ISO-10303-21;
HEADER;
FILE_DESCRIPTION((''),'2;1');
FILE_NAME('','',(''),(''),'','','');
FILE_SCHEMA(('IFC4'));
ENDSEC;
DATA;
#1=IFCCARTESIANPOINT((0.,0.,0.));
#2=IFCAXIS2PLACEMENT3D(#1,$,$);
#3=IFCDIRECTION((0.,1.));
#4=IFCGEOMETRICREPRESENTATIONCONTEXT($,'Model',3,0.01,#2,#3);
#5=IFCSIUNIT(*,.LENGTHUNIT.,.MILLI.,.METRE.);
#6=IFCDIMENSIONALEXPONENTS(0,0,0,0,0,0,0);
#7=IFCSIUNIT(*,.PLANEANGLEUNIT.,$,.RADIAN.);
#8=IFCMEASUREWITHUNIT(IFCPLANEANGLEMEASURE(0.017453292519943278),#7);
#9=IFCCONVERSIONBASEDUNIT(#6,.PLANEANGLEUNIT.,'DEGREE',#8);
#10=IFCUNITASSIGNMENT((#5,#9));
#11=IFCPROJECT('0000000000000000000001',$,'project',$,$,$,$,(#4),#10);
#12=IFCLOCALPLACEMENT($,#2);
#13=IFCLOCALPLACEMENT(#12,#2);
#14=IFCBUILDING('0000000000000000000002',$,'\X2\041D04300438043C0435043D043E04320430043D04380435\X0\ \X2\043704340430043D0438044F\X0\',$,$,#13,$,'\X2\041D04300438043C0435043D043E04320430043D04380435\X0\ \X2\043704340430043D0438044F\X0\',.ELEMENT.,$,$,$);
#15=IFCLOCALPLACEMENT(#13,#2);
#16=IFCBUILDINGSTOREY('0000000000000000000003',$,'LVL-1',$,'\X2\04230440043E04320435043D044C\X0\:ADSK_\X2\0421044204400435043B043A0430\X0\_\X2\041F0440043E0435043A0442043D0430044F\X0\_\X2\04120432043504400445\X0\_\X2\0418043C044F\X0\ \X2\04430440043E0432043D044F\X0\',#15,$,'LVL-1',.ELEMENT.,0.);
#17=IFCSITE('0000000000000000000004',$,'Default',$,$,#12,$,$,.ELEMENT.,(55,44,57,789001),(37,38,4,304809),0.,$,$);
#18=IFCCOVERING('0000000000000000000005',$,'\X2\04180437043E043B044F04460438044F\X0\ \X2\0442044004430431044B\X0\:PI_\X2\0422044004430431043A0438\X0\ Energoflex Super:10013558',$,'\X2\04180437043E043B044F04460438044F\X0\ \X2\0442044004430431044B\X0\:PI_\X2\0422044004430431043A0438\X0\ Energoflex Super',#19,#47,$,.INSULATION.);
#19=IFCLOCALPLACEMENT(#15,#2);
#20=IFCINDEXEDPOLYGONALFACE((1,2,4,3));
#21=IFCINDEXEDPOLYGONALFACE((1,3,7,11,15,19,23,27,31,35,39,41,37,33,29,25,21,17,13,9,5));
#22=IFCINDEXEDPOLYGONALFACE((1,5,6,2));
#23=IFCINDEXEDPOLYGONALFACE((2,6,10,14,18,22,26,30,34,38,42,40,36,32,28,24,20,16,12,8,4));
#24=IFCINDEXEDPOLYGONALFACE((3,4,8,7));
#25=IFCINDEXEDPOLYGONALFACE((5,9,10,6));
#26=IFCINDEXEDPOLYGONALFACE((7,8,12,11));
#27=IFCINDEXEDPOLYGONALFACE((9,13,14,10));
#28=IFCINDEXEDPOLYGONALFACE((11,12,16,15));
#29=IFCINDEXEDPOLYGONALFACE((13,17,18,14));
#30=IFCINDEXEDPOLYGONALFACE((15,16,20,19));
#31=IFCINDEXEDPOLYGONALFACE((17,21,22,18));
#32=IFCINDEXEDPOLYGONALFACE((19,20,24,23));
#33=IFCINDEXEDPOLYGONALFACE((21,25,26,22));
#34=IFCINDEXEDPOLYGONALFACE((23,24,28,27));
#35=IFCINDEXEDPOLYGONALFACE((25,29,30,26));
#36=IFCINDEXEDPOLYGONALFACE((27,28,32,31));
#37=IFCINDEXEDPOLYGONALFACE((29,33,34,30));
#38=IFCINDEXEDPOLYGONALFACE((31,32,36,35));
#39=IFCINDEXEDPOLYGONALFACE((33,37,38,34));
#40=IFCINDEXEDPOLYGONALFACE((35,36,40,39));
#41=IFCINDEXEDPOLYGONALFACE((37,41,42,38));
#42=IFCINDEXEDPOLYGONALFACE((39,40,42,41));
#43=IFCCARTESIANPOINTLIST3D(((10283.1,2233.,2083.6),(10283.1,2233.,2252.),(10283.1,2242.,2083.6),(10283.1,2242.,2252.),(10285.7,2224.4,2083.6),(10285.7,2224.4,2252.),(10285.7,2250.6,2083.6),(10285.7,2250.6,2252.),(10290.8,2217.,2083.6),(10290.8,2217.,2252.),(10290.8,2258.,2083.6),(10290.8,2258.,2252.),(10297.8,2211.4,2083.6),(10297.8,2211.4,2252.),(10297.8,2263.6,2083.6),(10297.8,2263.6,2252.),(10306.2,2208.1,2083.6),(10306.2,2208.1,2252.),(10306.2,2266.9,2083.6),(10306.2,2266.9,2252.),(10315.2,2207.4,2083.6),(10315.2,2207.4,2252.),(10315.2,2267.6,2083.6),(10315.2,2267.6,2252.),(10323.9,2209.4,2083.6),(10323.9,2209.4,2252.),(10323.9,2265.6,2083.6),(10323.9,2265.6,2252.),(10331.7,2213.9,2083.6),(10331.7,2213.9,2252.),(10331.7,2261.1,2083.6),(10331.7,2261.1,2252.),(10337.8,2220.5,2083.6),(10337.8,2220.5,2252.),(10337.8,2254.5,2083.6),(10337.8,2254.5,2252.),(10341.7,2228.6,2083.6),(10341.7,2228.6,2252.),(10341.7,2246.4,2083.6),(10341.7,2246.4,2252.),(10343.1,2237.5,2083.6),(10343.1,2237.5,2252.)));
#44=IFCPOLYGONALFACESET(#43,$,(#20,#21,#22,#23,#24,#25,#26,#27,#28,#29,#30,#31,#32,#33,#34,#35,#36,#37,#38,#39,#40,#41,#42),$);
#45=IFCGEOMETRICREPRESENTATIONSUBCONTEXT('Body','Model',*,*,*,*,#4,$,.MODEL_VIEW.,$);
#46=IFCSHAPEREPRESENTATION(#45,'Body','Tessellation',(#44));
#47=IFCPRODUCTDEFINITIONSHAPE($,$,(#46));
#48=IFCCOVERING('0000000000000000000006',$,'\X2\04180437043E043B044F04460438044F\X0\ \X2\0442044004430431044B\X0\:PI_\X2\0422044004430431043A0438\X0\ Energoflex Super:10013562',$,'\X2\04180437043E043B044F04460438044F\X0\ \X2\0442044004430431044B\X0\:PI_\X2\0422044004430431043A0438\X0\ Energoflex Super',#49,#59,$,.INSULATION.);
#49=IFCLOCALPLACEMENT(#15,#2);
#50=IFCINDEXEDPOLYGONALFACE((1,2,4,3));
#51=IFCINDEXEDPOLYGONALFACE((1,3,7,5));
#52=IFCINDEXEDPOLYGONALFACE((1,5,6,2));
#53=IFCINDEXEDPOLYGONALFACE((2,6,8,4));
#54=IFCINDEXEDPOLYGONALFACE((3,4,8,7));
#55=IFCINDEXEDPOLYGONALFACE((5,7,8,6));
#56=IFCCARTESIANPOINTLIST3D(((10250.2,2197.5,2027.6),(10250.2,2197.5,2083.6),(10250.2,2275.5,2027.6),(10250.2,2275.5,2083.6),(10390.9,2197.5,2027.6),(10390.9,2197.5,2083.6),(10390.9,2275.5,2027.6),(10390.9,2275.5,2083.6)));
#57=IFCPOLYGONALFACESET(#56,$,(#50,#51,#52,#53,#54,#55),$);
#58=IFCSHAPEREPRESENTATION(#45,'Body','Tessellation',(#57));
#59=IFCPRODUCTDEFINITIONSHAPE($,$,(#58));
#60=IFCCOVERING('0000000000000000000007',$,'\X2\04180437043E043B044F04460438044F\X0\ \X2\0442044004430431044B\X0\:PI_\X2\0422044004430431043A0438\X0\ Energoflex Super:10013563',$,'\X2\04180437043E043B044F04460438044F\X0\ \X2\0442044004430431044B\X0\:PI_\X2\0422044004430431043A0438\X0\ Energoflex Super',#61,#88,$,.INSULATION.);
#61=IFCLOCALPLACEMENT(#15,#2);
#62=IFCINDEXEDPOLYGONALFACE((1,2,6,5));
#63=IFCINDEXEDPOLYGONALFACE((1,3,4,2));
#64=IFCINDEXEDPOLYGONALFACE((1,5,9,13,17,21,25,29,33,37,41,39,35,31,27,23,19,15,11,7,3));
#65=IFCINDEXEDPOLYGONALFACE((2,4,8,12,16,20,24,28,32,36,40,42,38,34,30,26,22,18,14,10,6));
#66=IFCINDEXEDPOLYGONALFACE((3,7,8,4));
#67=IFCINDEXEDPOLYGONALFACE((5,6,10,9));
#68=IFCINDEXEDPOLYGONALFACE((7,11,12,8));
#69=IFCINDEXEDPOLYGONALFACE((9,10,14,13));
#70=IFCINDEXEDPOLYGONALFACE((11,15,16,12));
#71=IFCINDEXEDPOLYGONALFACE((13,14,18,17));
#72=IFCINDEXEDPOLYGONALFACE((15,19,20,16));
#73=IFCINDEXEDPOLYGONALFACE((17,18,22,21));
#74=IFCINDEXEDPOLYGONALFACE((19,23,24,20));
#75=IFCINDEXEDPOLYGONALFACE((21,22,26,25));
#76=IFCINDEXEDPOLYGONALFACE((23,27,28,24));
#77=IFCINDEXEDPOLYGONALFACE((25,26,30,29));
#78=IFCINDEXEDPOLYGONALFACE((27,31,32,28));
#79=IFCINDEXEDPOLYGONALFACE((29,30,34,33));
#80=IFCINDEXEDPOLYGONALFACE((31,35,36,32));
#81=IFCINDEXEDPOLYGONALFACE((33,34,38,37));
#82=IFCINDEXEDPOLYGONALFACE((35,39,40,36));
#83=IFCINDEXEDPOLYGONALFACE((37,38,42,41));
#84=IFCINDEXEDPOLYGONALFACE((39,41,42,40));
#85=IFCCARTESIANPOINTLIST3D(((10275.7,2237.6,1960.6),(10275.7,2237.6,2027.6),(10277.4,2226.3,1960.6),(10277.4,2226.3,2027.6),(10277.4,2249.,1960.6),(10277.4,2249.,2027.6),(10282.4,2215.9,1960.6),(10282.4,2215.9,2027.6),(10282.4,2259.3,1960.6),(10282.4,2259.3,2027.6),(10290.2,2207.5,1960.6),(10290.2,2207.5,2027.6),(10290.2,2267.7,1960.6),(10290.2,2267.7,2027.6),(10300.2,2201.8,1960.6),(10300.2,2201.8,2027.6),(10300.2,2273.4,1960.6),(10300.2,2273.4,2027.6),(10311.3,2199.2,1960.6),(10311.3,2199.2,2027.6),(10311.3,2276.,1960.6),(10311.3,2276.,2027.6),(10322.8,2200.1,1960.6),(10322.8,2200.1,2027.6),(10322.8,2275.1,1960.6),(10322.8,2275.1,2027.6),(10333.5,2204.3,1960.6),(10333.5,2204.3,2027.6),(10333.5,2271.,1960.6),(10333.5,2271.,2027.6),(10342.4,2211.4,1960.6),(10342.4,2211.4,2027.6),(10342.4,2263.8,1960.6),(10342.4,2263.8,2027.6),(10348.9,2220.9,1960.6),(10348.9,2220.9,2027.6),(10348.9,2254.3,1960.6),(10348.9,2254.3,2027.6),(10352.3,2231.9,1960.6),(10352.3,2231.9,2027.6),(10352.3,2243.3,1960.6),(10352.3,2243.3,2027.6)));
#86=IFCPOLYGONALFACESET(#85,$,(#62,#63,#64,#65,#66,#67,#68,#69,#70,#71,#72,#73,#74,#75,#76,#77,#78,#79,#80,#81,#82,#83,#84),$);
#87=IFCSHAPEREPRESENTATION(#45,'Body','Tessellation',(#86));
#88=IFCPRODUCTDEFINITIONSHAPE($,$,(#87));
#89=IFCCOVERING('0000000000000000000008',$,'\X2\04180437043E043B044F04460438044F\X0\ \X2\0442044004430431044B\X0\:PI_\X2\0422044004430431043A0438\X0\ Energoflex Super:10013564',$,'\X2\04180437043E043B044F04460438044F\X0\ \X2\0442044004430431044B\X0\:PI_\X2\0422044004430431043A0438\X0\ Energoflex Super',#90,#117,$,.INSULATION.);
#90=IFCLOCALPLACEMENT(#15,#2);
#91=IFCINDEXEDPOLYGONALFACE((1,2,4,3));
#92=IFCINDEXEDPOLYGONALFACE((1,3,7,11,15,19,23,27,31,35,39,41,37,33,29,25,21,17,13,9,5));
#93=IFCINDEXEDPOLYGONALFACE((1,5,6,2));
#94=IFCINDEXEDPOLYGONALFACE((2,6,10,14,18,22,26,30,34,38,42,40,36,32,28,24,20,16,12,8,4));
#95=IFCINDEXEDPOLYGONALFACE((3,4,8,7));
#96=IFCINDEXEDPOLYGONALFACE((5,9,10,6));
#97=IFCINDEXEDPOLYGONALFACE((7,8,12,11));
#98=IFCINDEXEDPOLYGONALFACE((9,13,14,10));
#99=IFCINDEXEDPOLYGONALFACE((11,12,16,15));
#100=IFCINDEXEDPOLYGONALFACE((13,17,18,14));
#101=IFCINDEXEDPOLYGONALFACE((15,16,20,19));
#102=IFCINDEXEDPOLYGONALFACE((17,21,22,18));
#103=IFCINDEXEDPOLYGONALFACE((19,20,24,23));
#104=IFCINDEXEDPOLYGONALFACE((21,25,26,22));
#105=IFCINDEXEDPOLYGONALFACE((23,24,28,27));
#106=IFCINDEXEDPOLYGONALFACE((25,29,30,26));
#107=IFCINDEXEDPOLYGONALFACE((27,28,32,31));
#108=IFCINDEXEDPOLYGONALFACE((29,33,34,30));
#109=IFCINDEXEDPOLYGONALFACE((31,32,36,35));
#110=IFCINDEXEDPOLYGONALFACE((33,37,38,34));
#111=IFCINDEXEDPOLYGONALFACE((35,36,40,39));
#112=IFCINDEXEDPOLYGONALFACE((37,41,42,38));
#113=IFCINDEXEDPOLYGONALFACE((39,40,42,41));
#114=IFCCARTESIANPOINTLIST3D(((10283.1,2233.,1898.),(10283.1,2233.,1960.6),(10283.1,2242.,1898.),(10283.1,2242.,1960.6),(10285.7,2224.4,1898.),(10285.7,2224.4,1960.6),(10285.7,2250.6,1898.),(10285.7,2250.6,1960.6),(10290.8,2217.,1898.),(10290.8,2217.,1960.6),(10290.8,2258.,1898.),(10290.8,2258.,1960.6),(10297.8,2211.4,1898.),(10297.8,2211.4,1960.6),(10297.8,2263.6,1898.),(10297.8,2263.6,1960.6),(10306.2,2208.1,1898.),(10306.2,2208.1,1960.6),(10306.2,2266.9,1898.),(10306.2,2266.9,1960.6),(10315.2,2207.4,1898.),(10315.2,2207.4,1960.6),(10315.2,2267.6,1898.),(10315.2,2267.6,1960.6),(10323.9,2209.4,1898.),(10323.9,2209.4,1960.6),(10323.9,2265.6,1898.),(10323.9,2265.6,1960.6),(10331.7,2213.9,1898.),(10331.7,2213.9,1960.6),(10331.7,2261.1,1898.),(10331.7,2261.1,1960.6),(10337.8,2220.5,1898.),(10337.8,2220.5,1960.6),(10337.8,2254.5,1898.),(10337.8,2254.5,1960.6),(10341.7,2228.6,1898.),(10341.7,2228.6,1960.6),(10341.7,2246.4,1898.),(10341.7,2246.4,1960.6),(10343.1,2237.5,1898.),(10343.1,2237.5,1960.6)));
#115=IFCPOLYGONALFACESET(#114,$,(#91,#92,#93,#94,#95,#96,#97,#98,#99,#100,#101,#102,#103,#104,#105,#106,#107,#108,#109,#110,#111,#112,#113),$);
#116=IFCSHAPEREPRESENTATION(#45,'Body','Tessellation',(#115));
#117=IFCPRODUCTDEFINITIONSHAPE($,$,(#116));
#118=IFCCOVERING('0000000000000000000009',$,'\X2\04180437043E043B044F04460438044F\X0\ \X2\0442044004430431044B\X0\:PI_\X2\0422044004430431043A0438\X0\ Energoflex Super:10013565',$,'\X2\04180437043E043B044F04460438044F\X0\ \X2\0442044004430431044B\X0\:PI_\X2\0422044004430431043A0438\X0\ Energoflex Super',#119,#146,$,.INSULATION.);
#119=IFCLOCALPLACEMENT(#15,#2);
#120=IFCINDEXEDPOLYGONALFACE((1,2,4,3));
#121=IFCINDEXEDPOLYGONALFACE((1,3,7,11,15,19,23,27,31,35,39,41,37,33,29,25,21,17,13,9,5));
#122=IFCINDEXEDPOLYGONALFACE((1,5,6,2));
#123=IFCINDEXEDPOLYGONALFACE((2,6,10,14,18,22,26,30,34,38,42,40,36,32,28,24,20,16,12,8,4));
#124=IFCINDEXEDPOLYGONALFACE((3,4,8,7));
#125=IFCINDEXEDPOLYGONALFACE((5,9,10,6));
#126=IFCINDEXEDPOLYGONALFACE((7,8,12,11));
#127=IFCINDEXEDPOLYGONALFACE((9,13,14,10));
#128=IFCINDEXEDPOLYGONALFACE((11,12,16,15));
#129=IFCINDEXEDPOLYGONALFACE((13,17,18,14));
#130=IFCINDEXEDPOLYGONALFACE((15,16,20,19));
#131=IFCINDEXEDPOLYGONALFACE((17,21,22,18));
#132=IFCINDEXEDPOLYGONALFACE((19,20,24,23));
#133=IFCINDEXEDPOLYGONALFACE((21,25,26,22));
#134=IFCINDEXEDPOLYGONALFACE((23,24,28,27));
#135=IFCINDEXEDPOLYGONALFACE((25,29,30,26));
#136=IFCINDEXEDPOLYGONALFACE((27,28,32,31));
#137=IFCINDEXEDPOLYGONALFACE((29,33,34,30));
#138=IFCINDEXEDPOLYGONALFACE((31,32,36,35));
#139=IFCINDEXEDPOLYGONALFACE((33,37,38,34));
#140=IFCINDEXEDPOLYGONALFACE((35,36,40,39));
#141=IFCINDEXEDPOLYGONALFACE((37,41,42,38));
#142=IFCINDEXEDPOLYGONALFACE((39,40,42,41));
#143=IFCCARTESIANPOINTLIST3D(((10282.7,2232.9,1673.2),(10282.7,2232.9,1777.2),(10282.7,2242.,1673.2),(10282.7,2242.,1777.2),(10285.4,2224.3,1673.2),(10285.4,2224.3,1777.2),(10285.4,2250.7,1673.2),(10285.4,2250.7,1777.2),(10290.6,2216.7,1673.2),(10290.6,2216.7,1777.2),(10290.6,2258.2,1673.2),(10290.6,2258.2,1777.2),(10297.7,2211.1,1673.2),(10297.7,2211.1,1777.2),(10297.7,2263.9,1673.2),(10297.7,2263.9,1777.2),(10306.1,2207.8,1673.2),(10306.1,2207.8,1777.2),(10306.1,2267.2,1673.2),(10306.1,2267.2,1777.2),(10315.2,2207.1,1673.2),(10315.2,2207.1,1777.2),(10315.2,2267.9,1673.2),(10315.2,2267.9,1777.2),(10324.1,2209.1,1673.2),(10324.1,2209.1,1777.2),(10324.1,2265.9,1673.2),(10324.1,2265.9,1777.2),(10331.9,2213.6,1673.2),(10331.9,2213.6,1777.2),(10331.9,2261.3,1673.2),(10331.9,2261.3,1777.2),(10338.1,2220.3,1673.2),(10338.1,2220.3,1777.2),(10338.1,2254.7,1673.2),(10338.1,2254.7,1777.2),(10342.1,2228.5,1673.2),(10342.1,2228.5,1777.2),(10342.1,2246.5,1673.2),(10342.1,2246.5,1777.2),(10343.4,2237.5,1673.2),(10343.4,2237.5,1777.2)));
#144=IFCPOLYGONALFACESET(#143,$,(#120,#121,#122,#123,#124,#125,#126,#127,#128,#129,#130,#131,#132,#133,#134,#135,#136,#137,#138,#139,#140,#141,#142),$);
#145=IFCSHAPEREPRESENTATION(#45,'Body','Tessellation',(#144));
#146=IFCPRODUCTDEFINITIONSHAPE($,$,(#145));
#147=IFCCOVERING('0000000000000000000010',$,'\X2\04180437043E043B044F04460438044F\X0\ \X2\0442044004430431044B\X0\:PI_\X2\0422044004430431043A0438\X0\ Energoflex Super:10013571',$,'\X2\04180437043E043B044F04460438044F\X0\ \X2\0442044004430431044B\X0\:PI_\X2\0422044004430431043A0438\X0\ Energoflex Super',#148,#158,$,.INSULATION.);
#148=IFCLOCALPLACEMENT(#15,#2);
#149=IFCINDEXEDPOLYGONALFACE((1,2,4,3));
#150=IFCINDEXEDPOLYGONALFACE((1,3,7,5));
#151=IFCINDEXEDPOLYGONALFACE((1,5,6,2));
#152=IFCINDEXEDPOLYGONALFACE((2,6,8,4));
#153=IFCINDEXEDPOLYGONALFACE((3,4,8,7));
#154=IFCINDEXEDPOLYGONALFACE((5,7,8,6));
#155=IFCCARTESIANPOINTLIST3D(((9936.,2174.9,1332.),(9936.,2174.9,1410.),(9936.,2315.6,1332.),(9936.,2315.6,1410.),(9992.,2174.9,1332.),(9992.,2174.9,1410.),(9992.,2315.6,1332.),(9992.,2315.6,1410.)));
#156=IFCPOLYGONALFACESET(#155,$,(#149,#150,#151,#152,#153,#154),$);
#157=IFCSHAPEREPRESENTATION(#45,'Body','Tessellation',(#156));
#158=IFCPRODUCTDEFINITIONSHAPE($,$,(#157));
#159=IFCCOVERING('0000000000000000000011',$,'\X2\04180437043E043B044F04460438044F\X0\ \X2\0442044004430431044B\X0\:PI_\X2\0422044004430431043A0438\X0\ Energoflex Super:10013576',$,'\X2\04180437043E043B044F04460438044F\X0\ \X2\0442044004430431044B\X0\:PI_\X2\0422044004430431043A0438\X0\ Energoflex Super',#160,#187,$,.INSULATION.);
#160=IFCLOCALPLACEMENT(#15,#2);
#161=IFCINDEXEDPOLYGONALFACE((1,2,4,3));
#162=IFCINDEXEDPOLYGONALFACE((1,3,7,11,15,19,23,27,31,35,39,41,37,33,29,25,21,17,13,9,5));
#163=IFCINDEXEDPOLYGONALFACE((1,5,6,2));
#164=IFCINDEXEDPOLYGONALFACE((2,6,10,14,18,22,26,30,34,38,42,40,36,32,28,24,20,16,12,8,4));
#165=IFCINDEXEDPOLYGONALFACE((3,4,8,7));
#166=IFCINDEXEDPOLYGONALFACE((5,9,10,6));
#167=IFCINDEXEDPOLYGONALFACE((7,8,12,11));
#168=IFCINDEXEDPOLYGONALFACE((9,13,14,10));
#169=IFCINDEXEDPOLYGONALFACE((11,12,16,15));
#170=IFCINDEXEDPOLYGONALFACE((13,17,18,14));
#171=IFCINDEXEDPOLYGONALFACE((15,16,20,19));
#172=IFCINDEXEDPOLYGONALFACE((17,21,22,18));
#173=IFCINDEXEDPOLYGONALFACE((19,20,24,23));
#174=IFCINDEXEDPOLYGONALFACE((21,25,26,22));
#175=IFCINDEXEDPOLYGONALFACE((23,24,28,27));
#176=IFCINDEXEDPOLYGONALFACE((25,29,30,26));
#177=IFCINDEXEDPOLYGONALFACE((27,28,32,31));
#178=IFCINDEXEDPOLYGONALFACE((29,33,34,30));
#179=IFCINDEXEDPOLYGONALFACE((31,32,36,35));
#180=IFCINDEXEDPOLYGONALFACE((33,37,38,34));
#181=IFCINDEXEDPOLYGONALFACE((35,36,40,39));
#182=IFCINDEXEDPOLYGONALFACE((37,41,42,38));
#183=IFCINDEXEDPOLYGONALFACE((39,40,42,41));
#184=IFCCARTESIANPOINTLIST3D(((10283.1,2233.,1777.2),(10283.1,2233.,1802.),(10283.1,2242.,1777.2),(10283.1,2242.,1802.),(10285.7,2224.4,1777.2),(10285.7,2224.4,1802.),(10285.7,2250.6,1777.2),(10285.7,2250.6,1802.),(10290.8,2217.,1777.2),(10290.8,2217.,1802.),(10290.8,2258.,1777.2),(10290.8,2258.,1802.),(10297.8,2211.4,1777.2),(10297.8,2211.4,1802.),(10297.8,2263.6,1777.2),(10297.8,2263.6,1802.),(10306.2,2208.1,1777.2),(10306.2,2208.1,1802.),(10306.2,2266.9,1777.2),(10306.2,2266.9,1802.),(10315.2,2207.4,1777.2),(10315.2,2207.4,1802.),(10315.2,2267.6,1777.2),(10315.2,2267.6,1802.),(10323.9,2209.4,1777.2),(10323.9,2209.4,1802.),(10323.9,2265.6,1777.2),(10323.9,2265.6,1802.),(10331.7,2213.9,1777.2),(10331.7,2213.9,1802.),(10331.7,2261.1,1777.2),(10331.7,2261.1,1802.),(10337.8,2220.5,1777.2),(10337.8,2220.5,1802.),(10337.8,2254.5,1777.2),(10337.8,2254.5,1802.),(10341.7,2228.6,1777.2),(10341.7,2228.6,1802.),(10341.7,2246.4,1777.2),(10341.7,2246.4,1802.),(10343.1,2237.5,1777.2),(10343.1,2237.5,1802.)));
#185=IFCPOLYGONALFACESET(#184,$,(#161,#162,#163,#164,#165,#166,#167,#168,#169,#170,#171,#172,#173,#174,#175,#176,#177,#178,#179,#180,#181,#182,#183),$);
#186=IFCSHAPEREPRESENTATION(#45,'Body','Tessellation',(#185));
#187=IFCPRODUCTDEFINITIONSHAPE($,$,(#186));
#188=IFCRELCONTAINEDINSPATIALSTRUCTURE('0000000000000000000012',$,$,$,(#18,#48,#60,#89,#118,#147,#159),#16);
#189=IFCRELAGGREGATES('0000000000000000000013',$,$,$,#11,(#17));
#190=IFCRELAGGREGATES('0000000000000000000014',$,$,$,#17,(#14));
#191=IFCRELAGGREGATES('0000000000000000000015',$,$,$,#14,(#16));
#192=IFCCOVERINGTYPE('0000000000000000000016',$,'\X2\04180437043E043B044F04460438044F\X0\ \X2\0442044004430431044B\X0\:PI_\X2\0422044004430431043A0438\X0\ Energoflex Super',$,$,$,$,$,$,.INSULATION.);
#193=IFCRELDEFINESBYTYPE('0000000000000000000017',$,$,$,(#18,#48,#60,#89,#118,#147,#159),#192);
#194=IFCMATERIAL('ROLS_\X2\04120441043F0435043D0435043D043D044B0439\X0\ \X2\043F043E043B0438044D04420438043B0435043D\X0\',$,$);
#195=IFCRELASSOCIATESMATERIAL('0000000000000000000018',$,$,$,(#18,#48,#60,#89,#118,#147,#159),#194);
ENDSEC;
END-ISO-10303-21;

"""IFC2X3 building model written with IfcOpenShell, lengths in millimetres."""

from ifc_helpers import new_model, entity, si_unit, converted_unit, direction, frame, frame_2d, origin, origin_2d_with_axis, place, context, subcontext, project, spatial, rectangle, circle, extrude, material, type_object, element, save


model = new_model("IFC2X3")

# Units and contexts
model_context = context("Model", 3, precision=0.01, world=origin(), true_north=direction((0.0, 1.0)))
body_context = subcontext(model_context, "Body", "Model", "MODEL_VIEW")
ifc_project = project(units=[si_unit("LENGTHUNIT", "METRE", prefix="MILLI"), converted_unit("PLANEANGLEUNIT", "DEGREE", entity("IfcPlaneAngleMeasure", 0.017453292519943278), si_unit("PLANEANGLEUNIT", "RADIAN"), dimensions=[0, 0, 0, 0, 0, 0, 0])], contexts=[model_context])

# Site, building, storey
site_placement = place(None, origin())
site = spatial("IfcSite", under=ifc_project, at=site_placement, Name="Default", CompositionType="ELEMENT", RefLatitude=(55, 44, 57, 789001), RefLongitude=(37, 38, 4, 304809), RefElevation=0.0)
building_placement = place(site_placement, origin())
building = spatial("IfcBuilding", under=site, at=building_placement, Name="Наименование здания", LongName="Наименование здания", CompositionType="ELEMENT")
storey_placement = place(building_placement, origin())
storey = spatial("IfcBuildingStorey", under=building, at=storey_placement, Name="LVL-1", ObjectType="Уровень:ADSK_Стрелка_Проектная_Вверх_Имя уровня", LongName="LVL-1", CompositionType="ELEMENT", Elevation=0.0)

# Coverings
ifc_material_1 = material(Name="ROLS_Вспененный полиэтилен")
covering_type = type_object("IfcCoveringType", Name="Изоляция трубы:PI_Трубки Energoflex Super", PredefinedType="INSULATION")
covering_1_placement = place(storey_placement, origin())
element("IfcCovering", 1, at=covering_1_placement, inside=storey, type_object=covering_type, material=ifc_material_1, Name="Изоляция трубы:PI_Трубки Energoflex Super:10013558", ObjectType="Изоляция трубы:PI_Трубки Energoflex Super", PredefinedType="INSULATION", context=body_context, shape_type="SweptSolid", body=[
    extrude(circle(Radius=30.1, at=frame_2d((0.0, 0.0), x_axis=(1.0, 0.0))), frame((10312.9, 2237.5, 2083.6)), (0.0, 0.0, 1.0), 168.4),
])
covering_2_placement = place(storey_placement, origin())
element("IfcCovering", 2, at=covering_2_placement, inside=storey, type_object=covering_type, material=ifc_material_1, Name="Изоляция трубы:PI_Трубки Energoflex Super:10013562", ObjectType="Изоляция трубы:PI_Трубки Energoflex Super", PredefinedType="INSULATION", context=body_context, shape_type="SweptSolid", body=[
    extrude(rectangle(XDim=140.7, YDim=78.0, at=frame_2d((0.0, 0.0), x_axis=(1.0, 0.0))), frame((10320.5, 2236.5, 2027.6)), (0.0, 0.0, 1.0), 56.0),
])
covering_3_placement = place(storey_placement, origin())
element("IfcCovering", 3, at=covering_3_placement, inside=storey, type_object=covering_type, material=ifc_material_1, Name="Изоляция трубы:PI_Трубки Energoflex Super:10013563", ObjectType="Изоляция трубы:PI_Трубки Energoflex Super", PredefinedType="INSULATION", context=body_context, shape_type="SweptSolid", body=[
    extrude(circle(Radius=38.5, at=origin_2d_with_axis()), frame((10314.2, 2237.6, 1960.6), z_axis=(0.0, 0.0, 1.0), x_axis=(-1.0, 0.0, 0.0)), (0.0, 0.0, 1.0), 67.0),
])
covering_4_placement = place(storey_placement, origin())
element("IfcCovering", 4, at=covering_4_placement, inside=storey, type_object=covering_type, material=ifc_material_1, Name="Изоляция трубы:PI_Трубки Energoflex Super:10013564", ObjectType="Изоляция трубы:PI_Трубки Energoflex Super", PredefinedType="INSULATION", context=body_context, shape_type="SweptSolid", body=[
    extrude(circle(Radius=30.1, at=frame_2d((0.0, 0.0), x_axis=(1.0, 0.0))), frame((10312.9, 2237.5, 1898.0)), (0.0, 0.0, 1.0), 62.6),
])
covering_5_placement = place(storey_placement, origin())
element("IfcCovering", 5, at=covering_5_placement, inside=storey, type_object=covering_type, material=ifc_material_1, Name="Изоляция трубы:PI_Трубки Energoflex Super:10013565", ObjectType="Изоляция трубы:PI_Трубки Energoflex Super", PredefinedType="INSULATION", context=body_context, shape_type="SweptSolid", body=[
    extrude(circle(Radius=30.5, at=origin_2d_with_axis()), frame((10312.9, 2237.5, 1673.2)), (0.0, 0.0, 1.0), 104.0),
])
covering_6_placement = place(storey_placement, origin())
element("IfcCovering", 6, at=covering_6_placement, inside=storey, type_object=covering_type, material=ifc_material_1, Name="Изоляция трубы:PI_Трубки Energoflex Super:10013571", ObjectType="Изоляция трубы:PI_Трубки Energoflex Super", PredefinedType="INSULATION", context=body_context, shape_type="SweptSolid", body=[
    extrude(rectangle(XDim=140.7, YDim=56.0, at=frame_2d((0.0, 0.0), x_axis=(1.0, 0.0))), frame((9964.0, 2245.2, 1332.0), z_axis=(0.0, 0.0, 1.0), x_axis=(0.0, -1.0, 0.0)), (0.0, 0.0, 1.0), 78.0),
])
covering_7_placement = place(storey_placement, origin())
element("IfcCovering", 7, at=covering_7_placement, inside=storey, type_object=covering_type, material=ifc_material_1, Name="Изоляция трубы:PI_Трубки Energoflex Super:10013576", ObjectType="Изоляция трубы:PI_Трубки Energoflex Super", PredefinedType="INSULATION", context=body_context, shape_type="SweptSolid", body=[
    extrude(circle(Radius=30.1, at=frame_2d((0.0, 0.0), x_axis=(1.0, 0.0))), frame((10312.9, 2237.5, 1777.2)), (0.0, 0.0, 1.0), 24.8),
])

save(model, "model.ifc")
